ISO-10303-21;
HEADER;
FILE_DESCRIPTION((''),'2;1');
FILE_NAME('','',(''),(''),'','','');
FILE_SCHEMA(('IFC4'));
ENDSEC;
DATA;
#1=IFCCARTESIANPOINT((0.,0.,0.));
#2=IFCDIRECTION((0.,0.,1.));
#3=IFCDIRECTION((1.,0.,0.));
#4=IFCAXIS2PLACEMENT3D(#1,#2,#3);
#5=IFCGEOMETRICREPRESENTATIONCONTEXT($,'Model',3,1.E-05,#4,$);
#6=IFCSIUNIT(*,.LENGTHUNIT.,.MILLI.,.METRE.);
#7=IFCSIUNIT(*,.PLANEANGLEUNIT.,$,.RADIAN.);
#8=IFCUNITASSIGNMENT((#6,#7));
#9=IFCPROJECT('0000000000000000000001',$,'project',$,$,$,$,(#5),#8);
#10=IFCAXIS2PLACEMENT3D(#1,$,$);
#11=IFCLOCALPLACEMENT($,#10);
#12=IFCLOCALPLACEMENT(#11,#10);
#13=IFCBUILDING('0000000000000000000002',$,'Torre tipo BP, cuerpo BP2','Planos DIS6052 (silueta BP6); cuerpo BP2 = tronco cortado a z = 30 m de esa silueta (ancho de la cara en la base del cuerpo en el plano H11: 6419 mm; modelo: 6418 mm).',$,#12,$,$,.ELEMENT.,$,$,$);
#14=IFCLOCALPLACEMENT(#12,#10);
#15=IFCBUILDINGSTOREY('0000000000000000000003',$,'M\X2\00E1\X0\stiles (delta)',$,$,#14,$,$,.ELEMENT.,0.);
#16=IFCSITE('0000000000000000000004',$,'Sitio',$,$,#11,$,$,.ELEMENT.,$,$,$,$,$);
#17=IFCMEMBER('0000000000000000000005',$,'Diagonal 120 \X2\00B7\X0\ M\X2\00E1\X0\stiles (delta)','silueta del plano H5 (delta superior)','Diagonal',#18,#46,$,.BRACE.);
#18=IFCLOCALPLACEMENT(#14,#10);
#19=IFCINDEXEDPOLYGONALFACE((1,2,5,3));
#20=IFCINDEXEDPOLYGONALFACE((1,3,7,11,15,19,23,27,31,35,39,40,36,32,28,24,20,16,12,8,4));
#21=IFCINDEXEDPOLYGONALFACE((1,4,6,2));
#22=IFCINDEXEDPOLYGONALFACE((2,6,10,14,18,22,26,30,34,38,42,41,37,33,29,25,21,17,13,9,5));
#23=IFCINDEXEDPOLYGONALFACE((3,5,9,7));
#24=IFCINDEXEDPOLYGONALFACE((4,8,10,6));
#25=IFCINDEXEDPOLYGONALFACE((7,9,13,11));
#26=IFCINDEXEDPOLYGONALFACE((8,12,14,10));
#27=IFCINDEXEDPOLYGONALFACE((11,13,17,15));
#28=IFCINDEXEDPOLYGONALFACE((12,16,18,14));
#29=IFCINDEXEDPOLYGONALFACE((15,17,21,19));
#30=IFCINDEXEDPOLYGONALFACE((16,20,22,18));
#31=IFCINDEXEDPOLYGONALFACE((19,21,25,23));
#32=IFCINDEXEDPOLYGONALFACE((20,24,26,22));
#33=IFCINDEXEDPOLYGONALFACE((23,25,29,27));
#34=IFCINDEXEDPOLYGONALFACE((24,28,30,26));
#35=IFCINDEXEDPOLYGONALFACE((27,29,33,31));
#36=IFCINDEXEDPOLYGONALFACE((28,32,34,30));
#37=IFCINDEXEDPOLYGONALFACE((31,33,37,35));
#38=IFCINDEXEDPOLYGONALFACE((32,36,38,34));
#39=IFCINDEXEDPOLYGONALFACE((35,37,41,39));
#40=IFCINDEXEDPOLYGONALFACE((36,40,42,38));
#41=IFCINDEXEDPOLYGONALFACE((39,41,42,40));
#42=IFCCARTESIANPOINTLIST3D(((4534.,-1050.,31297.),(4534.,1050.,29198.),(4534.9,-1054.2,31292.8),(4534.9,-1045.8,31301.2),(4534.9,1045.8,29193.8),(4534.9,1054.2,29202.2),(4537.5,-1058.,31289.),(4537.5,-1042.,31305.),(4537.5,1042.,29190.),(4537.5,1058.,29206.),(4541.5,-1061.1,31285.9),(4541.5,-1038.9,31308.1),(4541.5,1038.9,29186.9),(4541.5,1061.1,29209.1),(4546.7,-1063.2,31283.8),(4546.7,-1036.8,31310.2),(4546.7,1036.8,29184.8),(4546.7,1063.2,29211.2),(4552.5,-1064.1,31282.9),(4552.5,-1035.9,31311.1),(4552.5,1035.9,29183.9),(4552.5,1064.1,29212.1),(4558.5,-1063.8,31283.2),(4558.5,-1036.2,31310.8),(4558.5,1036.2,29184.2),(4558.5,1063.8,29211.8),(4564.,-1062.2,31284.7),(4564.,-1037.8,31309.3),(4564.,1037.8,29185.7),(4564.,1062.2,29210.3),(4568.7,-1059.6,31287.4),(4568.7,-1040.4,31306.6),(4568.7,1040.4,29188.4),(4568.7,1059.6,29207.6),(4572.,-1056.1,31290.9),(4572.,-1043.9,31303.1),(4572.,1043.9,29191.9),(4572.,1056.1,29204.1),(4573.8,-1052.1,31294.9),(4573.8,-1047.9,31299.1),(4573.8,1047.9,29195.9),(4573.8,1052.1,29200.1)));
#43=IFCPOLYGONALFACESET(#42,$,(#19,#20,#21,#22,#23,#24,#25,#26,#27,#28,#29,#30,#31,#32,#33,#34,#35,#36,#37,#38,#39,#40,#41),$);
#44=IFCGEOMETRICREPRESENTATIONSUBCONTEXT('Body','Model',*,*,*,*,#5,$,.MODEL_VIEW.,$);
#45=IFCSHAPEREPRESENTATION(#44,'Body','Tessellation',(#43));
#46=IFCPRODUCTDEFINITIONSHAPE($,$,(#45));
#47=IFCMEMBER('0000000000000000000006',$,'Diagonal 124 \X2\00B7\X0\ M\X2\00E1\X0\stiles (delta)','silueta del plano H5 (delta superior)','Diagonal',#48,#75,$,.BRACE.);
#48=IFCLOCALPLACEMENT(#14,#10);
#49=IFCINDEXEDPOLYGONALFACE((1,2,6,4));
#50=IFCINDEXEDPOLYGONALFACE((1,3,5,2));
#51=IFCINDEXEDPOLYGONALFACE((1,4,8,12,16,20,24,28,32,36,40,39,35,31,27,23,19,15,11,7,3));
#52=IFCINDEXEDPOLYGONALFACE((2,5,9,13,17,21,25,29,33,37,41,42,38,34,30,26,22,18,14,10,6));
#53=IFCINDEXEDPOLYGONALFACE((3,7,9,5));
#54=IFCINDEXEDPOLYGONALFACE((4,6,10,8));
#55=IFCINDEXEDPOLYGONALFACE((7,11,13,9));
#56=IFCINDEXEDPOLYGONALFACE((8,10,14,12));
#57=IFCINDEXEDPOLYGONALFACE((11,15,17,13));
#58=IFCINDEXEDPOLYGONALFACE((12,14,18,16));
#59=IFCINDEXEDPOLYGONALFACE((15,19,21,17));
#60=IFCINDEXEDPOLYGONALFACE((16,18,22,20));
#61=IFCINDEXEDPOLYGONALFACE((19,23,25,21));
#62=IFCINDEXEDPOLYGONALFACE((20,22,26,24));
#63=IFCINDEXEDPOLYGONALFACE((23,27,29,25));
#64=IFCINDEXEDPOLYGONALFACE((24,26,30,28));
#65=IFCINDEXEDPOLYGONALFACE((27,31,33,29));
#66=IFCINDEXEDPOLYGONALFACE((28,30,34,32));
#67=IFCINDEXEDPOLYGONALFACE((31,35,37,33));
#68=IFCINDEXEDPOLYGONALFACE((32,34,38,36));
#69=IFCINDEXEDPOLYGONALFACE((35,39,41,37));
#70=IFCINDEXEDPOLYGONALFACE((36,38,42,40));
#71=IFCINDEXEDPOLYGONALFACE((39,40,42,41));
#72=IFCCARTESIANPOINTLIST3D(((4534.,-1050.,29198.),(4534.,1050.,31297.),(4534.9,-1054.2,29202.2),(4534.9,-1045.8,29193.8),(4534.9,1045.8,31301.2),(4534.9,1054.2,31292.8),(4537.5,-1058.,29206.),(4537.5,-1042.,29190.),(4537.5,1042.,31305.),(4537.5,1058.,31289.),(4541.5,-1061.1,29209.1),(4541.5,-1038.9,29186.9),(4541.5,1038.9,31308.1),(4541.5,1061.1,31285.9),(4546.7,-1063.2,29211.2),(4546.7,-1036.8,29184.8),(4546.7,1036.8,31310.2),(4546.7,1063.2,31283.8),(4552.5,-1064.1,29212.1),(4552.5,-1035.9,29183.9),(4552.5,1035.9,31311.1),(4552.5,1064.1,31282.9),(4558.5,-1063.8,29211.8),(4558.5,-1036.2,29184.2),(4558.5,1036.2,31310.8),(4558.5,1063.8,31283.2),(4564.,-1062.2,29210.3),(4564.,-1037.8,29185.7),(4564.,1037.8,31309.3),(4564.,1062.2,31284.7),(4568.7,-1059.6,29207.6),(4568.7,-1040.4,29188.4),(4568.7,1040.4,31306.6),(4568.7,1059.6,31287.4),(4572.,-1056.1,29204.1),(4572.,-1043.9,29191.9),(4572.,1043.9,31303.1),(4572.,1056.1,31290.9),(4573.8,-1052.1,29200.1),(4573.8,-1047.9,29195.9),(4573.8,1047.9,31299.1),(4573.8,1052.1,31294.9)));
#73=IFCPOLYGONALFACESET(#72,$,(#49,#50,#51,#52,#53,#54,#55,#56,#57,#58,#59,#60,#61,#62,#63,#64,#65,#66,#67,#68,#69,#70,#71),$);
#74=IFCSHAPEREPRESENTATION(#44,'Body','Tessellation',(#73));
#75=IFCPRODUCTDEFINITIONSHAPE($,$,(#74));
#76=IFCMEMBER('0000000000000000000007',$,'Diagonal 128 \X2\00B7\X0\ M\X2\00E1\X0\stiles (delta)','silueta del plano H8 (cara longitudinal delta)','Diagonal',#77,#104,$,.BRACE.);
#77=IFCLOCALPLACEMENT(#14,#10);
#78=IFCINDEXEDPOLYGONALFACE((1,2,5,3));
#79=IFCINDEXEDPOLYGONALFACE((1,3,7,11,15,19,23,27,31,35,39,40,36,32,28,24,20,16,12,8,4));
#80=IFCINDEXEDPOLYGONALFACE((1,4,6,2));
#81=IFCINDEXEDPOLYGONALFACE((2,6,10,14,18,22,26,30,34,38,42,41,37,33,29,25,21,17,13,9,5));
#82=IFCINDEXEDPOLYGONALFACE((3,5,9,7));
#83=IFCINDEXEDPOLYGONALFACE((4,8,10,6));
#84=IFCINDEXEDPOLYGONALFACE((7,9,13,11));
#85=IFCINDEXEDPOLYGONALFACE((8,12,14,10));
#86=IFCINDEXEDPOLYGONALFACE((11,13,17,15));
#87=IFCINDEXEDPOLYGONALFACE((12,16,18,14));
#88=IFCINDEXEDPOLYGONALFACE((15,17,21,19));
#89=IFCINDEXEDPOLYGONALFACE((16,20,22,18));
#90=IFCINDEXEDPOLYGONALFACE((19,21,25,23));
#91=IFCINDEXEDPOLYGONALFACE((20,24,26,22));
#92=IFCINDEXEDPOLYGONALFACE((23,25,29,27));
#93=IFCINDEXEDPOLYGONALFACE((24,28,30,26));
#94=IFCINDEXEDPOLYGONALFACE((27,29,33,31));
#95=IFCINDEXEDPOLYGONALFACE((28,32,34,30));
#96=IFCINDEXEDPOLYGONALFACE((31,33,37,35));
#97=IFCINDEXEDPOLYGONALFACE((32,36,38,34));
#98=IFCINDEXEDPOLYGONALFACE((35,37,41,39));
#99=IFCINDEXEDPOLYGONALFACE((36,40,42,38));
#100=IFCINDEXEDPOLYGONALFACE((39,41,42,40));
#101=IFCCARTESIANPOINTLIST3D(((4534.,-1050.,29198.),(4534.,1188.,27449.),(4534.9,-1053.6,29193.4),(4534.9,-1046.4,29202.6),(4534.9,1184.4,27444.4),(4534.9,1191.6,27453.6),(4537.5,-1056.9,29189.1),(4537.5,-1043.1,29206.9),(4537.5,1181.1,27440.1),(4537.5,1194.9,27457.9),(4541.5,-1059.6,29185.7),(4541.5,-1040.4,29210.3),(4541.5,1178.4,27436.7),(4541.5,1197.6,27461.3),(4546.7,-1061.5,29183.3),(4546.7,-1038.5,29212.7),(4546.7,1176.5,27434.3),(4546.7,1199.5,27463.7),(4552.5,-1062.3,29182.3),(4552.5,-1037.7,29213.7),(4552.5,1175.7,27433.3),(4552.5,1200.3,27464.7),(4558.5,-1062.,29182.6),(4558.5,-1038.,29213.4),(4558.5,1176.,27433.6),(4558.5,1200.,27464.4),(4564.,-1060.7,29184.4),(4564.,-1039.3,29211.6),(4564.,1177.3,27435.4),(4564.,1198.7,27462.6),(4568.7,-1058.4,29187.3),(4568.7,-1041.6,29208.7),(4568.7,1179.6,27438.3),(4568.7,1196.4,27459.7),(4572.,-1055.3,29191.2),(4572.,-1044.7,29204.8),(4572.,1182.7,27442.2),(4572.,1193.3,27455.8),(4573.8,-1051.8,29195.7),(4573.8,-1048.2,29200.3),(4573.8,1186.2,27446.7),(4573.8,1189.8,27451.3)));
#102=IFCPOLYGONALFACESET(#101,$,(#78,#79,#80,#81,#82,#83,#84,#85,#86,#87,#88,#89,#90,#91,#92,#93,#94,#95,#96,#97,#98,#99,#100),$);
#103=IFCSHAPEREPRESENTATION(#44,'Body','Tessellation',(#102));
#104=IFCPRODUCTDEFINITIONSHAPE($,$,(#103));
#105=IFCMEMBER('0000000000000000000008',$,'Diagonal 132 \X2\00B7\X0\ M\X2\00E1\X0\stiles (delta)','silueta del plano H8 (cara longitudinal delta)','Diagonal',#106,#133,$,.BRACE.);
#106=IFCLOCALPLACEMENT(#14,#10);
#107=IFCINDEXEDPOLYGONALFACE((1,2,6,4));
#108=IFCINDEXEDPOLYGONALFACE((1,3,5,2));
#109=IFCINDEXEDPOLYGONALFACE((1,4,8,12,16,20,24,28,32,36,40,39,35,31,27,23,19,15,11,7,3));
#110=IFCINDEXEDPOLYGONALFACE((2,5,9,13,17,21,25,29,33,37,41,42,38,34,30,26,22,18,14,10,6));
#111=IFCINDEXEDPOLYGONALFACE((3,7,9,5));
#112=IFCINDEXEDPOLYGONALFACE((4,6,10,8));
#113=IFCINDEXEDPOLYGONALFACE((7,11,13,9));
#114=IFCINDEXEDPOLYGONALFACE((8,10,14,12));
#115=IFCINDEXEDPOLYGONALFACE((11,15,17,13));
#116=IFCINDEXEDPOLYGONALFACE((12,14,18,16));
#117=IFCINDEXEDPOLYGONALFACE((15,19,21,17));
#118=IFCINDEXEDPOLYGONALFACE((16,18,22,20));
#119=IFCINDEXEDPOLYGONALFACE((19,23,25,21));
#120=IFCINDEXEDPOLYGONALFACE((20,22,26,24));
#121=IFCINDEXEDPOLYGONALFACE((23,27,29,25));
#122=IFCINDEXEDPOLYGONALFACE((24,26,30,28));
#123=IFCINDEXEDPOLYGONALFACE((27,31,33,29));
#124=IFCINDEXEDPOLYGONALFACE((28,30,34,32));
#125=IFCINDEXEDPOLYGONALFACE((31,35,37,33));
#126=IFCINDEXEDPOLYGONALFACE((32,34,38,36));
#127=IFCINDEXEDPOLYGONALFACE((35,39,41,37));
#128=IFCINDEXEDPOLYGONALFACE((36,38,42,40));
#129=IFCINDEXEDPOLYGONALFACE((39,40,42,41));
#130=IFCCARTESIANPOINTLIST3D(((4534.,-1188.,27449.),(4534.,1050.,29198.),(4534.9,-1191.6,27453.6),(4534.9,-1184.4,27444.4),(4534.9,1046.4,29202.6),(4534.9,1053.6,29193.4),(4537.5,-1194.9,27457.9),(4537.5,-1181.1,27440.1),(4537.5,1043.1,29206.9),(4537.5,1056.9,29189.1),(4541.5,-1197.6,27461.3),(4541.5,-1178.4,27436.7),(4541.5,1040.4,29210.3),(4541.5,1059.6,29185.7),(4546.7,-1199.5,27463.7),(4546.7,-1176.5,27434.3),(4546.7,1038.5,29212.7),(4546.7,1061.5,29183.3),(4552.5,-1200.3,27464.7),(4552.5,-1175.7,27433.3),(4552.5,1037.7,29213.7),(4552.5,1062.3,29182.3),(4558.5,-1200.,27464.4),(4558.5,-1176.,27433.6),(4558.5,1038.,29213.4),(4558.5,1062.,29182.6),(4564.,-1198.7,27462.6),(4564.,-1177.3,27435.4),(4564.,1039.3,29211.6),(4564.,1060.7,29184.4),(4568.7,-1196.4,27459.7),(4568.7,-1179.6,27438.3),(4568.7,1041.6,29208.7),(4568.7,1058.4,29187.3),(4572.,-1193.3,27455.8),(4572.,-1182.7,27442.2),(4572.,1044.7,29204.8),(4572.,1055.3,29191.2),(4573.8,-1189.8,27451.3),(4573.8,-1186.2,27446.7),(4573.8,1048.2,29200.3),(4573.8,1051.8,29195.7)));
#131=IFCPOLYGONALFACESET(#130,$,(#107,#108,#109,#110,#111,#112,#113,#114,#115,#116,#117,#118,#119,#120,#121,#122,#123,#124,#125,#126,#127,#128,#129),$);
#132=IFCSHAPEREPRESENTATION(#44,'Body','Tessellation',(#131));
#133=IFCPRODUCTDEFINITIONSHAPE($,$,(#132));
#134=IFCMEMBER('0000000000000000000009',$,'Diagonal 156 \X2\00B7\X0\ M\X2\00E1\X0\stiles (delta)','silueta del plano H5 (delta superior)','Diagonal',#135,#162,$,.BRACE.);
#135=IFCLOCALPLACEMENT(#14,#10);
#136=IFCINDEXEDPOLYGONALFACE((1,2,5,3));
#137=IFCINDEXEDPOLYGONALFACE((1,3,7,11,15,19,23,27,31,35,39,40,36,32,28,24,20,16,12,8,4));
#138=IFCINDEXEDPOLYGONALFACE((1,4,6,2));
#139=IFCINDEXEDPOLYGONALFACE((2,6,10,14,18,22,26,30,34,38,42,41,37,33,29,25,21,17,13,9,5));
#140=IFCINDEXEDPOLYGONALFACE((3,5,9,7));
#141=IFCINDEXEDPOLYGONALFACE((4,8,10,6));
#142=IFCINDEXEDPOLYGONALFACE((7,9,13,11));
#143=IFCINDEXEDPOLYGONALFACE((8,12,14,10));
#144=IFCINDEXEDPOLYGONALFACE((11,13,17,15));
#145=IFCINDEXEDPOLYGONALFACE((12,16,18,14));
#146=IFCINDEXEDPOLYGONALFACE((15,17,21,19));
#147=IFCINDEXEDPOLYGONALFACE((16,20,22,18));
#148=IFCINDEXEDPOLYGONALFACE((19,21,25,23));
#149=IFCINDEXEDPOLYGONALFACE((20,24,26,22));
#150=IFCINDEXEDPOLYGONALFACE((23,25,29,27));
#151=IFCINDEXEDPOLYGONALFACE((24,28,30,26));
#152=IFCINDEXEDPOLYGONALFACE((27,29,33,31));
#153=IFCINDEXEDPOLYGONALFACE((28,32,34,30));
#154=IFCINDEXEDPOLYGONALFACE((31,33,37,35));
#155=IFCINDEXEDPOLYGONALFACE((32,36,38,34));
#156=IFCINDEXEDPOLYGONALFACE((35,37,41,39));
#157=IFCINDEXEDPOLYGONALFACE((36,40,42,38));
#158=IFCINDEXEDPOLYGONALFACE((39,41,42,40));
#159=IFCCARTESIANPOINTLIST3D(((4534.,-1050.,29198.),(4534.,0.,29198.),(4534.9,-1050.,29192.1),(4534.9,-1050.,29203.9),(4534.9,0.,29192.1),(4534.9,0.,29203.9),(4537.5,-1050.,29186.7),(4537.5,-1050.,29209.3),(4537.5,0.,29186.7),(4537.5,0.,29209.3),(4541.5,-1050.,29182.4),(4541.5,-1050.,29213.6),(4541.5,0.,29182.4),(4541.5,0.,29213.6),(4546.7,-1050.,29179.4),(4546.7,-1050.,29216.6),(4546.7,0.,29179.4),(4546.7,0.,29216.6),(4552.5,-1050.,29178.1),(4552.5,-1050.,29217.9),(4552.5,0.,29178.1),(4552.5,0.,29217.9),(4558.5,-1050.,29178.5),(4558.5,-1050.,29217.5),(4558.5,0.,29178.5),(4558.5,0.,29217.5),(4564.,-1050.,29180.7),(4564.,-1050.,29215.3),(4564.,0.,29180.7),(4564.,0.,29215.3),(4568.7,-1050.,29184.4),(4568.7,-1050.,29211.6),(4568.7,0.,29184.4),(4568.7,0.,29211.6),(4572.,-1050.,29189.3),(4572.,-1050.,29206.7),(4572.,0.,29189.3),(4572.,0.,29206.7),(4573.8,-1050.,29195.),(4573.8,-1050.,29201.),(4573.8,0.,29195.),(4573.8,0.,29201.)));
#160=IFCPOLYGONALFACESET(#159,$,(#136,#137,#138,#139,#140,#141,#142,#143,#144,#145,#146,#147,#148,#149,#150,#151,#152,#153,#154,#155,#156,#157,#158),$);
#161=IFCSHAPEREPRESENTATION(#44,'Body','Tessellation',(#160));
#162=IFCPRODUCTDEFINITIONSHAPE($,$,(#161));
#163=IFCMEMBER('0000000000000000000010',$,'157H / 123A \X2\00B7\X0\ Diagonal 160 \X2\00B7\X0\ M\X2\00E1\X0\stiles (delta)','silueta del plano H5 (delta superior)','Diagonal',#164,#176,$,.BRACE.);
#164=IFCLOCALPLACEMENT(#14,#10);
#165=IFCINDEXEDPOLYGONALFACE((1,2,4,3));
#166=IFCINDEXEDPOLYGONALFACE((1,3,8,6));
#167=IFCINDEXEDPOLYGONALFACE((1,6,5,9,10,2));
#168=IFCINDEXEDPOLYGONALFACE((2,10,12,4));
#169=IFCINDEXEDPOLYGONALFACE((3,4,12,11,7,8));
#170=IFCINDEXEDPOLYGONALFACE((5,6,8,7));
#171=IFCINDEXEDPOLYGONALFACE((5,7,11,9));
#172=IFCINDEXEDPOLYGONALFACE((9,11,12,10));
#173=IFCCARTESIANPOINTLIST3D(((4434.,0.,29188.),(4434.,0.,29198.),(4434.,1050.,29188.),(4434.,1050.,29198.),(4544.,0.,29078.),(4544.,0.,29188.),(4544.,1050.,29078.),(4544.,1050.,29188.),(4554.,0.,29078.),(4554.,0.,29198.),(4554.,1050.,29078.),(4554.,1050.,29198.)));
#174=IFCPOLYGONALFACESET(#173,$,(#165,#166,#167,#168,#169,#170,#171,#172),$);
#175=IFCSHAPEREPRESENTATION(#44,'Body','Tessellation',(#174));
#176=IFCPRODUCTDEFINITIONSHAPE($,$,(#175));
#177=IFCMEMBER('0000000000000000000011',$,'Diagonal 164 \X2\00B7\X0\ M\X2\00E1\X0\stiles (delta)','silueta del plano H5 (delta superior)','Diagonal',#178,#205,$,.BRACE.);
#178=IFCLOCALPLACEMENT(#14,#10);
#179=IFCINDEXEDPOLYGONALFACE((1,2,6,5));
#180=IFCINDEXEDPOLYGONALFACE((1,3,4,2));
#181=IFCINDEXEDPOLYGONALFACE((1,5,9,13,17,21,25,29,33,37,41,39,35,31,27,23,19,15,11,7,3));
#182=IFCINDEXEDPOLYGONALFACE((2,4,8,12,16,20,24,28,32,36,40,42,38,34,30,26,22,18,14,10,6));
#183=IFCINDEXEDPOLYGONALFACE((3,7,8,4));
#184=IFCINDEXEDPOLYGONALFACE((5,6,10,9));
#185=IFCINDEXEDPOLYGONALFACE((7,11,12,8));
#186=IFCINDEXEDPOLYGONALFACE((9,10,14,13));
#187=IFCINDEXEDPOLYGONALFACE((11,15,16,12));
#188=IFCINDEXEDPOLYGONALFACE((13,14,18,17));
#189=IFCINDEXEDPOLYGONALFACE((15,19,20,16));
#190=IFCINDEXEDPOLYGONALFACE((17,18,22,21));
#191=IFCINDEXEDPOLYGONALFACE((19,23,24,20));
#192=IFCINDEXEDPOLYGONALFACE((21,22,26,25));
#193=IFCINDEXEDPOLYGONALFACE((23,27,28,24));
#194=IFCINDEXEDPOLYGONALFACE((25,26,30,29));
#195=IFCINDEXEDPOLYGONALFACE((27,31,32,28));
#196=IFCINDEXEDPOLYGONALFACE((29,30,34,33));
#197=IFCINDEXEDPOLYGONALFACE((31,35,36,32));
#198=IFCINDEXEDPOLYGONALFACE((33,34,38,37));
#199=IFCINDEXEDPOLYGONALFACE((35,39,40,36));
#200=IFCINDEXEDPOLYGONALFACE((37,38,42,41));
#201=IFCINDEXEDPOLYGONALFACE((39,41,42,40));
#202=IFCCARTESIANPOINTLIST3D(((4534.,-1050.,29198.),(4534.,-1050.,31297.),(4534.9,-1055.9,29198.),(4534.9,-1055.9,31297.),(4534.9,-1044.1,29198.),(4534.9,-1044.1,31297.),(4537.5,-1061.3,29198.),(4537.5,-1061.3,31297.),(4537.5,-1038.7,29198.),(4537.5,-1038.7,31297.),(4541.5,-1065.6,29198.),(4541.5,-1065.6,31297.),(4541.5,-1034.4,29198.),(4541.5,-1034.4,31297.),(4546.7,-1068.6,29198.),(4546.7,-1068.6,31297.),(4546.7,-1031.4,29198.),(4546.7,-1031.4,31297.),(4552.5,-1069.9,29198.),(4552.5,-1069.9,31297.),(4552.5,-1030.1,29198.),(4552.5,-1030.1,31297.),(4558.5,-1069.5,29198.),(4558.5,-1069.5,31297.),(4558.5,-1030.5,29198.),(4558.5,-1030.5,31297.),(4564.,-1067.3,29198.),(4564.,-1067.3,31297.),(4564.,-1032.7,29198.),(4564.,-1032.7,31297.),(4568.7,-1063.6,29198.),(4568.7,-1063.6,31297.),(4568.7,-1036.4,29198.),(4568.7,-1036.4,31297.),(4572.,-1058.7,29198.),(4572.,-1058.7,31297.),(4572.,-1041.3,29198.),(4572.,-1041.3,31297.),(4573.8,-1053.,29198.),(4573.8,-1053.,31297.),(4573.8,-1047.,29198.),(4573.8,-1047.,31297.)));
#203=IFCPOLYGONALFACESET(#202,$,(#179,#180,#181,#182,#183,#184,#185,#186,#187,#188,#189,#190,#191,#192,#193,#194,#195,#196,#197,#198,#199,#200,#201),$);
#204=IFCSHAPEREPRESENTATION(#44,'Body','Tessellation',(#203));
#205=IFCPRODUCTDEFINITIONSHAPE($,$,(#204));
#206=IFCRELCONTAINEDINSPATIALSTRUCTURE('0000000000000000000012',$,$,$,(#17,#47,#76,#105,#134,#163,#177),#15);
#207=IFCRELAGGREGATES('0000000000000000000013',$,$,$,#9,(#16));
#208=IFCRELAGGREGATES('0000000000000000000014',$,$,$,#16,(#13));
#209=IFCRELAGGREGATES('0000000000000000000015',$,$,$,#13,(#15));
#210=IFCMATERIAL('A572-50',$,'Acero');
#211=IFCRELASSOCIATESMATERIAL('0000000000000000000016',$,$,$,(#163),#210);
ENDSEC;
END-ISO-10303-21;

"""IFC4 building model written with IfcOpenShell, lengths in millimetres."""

from ifc_helpers import new_model, si_unit, frame, frame_2d, origin, origin_with_axes, place, context, subcontext, project, spatial, circle, l_section, extrude, material, element, save


model = new_model("IFC4")

# Units and contexts
model_context = context("Model", 3, precision=1e-05, world=origin_with_axes())
body_context = subcontext(model_context, "Body", "Model", "MODEL_VIEW")
ifc_project = project(units=[si_unit("LENGTHUNIT", "METRE", prefix="MILLI"), si_unit("PLANEANGLEUNIT", "RADIAN")], contexts=[model_context])

# Site, building, storey
site_placement = place(None, origin())
site = spatial("IfcSite", under=ifc_project, at=site_placement, Name="Sitio", CompositionType="ELEMENT")
building_placement = place(site_placement, origin())
building = spatial("IfcBuilding", under=site, at=building_placement, Name="Torre tipo BP, cuerpo BP2", Description="Planos DIS6052 (silueta BP6); cuerpo BP2 = tronco cortado a z = 30 m de esa silueta (ancho de la cara en la base del cuerpo en el plano H11: 6419 mm; modelo: 6418 mm).", CompositionType="ELEMENT")
storey_placement = place(building_placement, origin())
storey = spatial("IfcBuildingStorey", under=building, at=storey_placement, Name="Mástiles (delta)", CompositionType="ELEMENT", Elevation=0.0)

# Members
for number, where, z_axis, x_axis, name in (
    (1, (4554.0, -1050.0, 31297.0), (0.0, 0.707275, -0.706938), (-1.0, 0.0, 0.0), "Diagonal 120 · Mástiles (delta)"),
    (2, (4554.0, 1050.0, 31297.0), (0.0, -0.707275, -0.706938), (-1.0, 0.0, 0.0), "Diagonal 124 · Mástiles (delta)"),
):
    element("IfcMember", number, at=place(storey_placement, frame(where, z_axis=z_axis, x_axis=x_axis)), inside=storey, Name=name, Description="silueta del plano H5 (delta superior)", ObjectType="Diagonal", PredefinedType="BRACE", context=body_context, shape_type="SweptSolid", body=[
        extrude(circle(Radius=20.0), None, (0.0, 0.0, 1.0), 2969.1),
    ])
for number, where, z_axis, x_axis, name in (
    (3, (4554.0, -1050.0, 29198.0), (0.0, 0.787928, -0.615767), (-1.0, 0.0, 0.0), "Diagonal 128 · Mástiles (delta)"),
    (4, (4554.0, 1050.0, 29198.0), (0.0, -0.787928, -0.615767), (-1.0, 0.0, 0.0), "Diagonal 132 · Mástiles (delta)"),
):
    element("IfcMember", number, at=place(storey_placement, frame(where, z_axis=z_axis, x_axis=x_axis)), inside=storey, Name=name, Description="silueta del plano H8 (cara longitudinal delta)", ObjectType="Diagonal", PredefinedType="BRACE", context=body_context, shape_type="SweptSolid", body=[
        extrude(circle(Radius=20.0), None, (0.0, 0.0, 1.0), 2840.4),
    ])
member_1_placement = place(storey_placement, frame((4554.0, -1050.0, 29198.0), z_axis=(0.0, 1.0, 0.0), x_axis=(-1.0, 0.0, 0.0)))
element("IfcMember", 5, at=member_1_placement, inside=storey, Name="Diagonal 156 · Mástiles (delta)", Description="silueta del plano H5 (delta superior)", ObjectType="Diagonal", PredefinedType="BRACE", context=body_context, shape_type="SweptSolid", body=[
    extrude(circle(Radius=20.0), None, (0.0, 0.0, 1.0), 1050.0),
])
ifc_material_1 = material(Name="A572-50", Category="Acero")
member_2_placement = place(storey_placement, frame((4554.0, 1050.0, 29198.0), z_axis=(0.0, -1.0, 0.0), x_axis=(-1.0, 0.0, 0.0)))
element("IfcMember", 6, at=member_2_placement, inside=storey, material=ifc_material_1, Name="157H / 123A · Diagonal 160 · Mástiles (delta)", Description="silueta del plano H5 (delta superior)", ObjectType="Diagonal", PredefinedType="BRACE", context=body_context, shape_type="SweptSolid", body=[
    extrude(l_section(Depth=120.0, Width=120.0, Thickness=10.0, at=frame_2d((60.0, 60.0))), None, (0.0, 0.0, 1.0), 1050.0),
])
for number, where, z_axis, x_axis, name in (
    (7, (4554.0, -1050.0, 31297.0), (0.0, 0.0, -1.0), (-1.0, 0.0, 0.0), "Diagonal 164 · Mástiles (delta)"),
):
    element("IfcMember", number, at=place(storey_placement, frame(where, z_axis=z_axis, x_axis=x_axis)), inside=storey, Name=name, Description="silueta del plano H5 (delta superior)", ObjectType="Diagonal", PredefinedType="BRACE", context=body_context, shape_type="SweptSolid", body=[
        extrude(circle(Radius=20.0), None, (0.0, 0.0, 1.0), 2099.0),
    ])

save(model, "model.ifc")
